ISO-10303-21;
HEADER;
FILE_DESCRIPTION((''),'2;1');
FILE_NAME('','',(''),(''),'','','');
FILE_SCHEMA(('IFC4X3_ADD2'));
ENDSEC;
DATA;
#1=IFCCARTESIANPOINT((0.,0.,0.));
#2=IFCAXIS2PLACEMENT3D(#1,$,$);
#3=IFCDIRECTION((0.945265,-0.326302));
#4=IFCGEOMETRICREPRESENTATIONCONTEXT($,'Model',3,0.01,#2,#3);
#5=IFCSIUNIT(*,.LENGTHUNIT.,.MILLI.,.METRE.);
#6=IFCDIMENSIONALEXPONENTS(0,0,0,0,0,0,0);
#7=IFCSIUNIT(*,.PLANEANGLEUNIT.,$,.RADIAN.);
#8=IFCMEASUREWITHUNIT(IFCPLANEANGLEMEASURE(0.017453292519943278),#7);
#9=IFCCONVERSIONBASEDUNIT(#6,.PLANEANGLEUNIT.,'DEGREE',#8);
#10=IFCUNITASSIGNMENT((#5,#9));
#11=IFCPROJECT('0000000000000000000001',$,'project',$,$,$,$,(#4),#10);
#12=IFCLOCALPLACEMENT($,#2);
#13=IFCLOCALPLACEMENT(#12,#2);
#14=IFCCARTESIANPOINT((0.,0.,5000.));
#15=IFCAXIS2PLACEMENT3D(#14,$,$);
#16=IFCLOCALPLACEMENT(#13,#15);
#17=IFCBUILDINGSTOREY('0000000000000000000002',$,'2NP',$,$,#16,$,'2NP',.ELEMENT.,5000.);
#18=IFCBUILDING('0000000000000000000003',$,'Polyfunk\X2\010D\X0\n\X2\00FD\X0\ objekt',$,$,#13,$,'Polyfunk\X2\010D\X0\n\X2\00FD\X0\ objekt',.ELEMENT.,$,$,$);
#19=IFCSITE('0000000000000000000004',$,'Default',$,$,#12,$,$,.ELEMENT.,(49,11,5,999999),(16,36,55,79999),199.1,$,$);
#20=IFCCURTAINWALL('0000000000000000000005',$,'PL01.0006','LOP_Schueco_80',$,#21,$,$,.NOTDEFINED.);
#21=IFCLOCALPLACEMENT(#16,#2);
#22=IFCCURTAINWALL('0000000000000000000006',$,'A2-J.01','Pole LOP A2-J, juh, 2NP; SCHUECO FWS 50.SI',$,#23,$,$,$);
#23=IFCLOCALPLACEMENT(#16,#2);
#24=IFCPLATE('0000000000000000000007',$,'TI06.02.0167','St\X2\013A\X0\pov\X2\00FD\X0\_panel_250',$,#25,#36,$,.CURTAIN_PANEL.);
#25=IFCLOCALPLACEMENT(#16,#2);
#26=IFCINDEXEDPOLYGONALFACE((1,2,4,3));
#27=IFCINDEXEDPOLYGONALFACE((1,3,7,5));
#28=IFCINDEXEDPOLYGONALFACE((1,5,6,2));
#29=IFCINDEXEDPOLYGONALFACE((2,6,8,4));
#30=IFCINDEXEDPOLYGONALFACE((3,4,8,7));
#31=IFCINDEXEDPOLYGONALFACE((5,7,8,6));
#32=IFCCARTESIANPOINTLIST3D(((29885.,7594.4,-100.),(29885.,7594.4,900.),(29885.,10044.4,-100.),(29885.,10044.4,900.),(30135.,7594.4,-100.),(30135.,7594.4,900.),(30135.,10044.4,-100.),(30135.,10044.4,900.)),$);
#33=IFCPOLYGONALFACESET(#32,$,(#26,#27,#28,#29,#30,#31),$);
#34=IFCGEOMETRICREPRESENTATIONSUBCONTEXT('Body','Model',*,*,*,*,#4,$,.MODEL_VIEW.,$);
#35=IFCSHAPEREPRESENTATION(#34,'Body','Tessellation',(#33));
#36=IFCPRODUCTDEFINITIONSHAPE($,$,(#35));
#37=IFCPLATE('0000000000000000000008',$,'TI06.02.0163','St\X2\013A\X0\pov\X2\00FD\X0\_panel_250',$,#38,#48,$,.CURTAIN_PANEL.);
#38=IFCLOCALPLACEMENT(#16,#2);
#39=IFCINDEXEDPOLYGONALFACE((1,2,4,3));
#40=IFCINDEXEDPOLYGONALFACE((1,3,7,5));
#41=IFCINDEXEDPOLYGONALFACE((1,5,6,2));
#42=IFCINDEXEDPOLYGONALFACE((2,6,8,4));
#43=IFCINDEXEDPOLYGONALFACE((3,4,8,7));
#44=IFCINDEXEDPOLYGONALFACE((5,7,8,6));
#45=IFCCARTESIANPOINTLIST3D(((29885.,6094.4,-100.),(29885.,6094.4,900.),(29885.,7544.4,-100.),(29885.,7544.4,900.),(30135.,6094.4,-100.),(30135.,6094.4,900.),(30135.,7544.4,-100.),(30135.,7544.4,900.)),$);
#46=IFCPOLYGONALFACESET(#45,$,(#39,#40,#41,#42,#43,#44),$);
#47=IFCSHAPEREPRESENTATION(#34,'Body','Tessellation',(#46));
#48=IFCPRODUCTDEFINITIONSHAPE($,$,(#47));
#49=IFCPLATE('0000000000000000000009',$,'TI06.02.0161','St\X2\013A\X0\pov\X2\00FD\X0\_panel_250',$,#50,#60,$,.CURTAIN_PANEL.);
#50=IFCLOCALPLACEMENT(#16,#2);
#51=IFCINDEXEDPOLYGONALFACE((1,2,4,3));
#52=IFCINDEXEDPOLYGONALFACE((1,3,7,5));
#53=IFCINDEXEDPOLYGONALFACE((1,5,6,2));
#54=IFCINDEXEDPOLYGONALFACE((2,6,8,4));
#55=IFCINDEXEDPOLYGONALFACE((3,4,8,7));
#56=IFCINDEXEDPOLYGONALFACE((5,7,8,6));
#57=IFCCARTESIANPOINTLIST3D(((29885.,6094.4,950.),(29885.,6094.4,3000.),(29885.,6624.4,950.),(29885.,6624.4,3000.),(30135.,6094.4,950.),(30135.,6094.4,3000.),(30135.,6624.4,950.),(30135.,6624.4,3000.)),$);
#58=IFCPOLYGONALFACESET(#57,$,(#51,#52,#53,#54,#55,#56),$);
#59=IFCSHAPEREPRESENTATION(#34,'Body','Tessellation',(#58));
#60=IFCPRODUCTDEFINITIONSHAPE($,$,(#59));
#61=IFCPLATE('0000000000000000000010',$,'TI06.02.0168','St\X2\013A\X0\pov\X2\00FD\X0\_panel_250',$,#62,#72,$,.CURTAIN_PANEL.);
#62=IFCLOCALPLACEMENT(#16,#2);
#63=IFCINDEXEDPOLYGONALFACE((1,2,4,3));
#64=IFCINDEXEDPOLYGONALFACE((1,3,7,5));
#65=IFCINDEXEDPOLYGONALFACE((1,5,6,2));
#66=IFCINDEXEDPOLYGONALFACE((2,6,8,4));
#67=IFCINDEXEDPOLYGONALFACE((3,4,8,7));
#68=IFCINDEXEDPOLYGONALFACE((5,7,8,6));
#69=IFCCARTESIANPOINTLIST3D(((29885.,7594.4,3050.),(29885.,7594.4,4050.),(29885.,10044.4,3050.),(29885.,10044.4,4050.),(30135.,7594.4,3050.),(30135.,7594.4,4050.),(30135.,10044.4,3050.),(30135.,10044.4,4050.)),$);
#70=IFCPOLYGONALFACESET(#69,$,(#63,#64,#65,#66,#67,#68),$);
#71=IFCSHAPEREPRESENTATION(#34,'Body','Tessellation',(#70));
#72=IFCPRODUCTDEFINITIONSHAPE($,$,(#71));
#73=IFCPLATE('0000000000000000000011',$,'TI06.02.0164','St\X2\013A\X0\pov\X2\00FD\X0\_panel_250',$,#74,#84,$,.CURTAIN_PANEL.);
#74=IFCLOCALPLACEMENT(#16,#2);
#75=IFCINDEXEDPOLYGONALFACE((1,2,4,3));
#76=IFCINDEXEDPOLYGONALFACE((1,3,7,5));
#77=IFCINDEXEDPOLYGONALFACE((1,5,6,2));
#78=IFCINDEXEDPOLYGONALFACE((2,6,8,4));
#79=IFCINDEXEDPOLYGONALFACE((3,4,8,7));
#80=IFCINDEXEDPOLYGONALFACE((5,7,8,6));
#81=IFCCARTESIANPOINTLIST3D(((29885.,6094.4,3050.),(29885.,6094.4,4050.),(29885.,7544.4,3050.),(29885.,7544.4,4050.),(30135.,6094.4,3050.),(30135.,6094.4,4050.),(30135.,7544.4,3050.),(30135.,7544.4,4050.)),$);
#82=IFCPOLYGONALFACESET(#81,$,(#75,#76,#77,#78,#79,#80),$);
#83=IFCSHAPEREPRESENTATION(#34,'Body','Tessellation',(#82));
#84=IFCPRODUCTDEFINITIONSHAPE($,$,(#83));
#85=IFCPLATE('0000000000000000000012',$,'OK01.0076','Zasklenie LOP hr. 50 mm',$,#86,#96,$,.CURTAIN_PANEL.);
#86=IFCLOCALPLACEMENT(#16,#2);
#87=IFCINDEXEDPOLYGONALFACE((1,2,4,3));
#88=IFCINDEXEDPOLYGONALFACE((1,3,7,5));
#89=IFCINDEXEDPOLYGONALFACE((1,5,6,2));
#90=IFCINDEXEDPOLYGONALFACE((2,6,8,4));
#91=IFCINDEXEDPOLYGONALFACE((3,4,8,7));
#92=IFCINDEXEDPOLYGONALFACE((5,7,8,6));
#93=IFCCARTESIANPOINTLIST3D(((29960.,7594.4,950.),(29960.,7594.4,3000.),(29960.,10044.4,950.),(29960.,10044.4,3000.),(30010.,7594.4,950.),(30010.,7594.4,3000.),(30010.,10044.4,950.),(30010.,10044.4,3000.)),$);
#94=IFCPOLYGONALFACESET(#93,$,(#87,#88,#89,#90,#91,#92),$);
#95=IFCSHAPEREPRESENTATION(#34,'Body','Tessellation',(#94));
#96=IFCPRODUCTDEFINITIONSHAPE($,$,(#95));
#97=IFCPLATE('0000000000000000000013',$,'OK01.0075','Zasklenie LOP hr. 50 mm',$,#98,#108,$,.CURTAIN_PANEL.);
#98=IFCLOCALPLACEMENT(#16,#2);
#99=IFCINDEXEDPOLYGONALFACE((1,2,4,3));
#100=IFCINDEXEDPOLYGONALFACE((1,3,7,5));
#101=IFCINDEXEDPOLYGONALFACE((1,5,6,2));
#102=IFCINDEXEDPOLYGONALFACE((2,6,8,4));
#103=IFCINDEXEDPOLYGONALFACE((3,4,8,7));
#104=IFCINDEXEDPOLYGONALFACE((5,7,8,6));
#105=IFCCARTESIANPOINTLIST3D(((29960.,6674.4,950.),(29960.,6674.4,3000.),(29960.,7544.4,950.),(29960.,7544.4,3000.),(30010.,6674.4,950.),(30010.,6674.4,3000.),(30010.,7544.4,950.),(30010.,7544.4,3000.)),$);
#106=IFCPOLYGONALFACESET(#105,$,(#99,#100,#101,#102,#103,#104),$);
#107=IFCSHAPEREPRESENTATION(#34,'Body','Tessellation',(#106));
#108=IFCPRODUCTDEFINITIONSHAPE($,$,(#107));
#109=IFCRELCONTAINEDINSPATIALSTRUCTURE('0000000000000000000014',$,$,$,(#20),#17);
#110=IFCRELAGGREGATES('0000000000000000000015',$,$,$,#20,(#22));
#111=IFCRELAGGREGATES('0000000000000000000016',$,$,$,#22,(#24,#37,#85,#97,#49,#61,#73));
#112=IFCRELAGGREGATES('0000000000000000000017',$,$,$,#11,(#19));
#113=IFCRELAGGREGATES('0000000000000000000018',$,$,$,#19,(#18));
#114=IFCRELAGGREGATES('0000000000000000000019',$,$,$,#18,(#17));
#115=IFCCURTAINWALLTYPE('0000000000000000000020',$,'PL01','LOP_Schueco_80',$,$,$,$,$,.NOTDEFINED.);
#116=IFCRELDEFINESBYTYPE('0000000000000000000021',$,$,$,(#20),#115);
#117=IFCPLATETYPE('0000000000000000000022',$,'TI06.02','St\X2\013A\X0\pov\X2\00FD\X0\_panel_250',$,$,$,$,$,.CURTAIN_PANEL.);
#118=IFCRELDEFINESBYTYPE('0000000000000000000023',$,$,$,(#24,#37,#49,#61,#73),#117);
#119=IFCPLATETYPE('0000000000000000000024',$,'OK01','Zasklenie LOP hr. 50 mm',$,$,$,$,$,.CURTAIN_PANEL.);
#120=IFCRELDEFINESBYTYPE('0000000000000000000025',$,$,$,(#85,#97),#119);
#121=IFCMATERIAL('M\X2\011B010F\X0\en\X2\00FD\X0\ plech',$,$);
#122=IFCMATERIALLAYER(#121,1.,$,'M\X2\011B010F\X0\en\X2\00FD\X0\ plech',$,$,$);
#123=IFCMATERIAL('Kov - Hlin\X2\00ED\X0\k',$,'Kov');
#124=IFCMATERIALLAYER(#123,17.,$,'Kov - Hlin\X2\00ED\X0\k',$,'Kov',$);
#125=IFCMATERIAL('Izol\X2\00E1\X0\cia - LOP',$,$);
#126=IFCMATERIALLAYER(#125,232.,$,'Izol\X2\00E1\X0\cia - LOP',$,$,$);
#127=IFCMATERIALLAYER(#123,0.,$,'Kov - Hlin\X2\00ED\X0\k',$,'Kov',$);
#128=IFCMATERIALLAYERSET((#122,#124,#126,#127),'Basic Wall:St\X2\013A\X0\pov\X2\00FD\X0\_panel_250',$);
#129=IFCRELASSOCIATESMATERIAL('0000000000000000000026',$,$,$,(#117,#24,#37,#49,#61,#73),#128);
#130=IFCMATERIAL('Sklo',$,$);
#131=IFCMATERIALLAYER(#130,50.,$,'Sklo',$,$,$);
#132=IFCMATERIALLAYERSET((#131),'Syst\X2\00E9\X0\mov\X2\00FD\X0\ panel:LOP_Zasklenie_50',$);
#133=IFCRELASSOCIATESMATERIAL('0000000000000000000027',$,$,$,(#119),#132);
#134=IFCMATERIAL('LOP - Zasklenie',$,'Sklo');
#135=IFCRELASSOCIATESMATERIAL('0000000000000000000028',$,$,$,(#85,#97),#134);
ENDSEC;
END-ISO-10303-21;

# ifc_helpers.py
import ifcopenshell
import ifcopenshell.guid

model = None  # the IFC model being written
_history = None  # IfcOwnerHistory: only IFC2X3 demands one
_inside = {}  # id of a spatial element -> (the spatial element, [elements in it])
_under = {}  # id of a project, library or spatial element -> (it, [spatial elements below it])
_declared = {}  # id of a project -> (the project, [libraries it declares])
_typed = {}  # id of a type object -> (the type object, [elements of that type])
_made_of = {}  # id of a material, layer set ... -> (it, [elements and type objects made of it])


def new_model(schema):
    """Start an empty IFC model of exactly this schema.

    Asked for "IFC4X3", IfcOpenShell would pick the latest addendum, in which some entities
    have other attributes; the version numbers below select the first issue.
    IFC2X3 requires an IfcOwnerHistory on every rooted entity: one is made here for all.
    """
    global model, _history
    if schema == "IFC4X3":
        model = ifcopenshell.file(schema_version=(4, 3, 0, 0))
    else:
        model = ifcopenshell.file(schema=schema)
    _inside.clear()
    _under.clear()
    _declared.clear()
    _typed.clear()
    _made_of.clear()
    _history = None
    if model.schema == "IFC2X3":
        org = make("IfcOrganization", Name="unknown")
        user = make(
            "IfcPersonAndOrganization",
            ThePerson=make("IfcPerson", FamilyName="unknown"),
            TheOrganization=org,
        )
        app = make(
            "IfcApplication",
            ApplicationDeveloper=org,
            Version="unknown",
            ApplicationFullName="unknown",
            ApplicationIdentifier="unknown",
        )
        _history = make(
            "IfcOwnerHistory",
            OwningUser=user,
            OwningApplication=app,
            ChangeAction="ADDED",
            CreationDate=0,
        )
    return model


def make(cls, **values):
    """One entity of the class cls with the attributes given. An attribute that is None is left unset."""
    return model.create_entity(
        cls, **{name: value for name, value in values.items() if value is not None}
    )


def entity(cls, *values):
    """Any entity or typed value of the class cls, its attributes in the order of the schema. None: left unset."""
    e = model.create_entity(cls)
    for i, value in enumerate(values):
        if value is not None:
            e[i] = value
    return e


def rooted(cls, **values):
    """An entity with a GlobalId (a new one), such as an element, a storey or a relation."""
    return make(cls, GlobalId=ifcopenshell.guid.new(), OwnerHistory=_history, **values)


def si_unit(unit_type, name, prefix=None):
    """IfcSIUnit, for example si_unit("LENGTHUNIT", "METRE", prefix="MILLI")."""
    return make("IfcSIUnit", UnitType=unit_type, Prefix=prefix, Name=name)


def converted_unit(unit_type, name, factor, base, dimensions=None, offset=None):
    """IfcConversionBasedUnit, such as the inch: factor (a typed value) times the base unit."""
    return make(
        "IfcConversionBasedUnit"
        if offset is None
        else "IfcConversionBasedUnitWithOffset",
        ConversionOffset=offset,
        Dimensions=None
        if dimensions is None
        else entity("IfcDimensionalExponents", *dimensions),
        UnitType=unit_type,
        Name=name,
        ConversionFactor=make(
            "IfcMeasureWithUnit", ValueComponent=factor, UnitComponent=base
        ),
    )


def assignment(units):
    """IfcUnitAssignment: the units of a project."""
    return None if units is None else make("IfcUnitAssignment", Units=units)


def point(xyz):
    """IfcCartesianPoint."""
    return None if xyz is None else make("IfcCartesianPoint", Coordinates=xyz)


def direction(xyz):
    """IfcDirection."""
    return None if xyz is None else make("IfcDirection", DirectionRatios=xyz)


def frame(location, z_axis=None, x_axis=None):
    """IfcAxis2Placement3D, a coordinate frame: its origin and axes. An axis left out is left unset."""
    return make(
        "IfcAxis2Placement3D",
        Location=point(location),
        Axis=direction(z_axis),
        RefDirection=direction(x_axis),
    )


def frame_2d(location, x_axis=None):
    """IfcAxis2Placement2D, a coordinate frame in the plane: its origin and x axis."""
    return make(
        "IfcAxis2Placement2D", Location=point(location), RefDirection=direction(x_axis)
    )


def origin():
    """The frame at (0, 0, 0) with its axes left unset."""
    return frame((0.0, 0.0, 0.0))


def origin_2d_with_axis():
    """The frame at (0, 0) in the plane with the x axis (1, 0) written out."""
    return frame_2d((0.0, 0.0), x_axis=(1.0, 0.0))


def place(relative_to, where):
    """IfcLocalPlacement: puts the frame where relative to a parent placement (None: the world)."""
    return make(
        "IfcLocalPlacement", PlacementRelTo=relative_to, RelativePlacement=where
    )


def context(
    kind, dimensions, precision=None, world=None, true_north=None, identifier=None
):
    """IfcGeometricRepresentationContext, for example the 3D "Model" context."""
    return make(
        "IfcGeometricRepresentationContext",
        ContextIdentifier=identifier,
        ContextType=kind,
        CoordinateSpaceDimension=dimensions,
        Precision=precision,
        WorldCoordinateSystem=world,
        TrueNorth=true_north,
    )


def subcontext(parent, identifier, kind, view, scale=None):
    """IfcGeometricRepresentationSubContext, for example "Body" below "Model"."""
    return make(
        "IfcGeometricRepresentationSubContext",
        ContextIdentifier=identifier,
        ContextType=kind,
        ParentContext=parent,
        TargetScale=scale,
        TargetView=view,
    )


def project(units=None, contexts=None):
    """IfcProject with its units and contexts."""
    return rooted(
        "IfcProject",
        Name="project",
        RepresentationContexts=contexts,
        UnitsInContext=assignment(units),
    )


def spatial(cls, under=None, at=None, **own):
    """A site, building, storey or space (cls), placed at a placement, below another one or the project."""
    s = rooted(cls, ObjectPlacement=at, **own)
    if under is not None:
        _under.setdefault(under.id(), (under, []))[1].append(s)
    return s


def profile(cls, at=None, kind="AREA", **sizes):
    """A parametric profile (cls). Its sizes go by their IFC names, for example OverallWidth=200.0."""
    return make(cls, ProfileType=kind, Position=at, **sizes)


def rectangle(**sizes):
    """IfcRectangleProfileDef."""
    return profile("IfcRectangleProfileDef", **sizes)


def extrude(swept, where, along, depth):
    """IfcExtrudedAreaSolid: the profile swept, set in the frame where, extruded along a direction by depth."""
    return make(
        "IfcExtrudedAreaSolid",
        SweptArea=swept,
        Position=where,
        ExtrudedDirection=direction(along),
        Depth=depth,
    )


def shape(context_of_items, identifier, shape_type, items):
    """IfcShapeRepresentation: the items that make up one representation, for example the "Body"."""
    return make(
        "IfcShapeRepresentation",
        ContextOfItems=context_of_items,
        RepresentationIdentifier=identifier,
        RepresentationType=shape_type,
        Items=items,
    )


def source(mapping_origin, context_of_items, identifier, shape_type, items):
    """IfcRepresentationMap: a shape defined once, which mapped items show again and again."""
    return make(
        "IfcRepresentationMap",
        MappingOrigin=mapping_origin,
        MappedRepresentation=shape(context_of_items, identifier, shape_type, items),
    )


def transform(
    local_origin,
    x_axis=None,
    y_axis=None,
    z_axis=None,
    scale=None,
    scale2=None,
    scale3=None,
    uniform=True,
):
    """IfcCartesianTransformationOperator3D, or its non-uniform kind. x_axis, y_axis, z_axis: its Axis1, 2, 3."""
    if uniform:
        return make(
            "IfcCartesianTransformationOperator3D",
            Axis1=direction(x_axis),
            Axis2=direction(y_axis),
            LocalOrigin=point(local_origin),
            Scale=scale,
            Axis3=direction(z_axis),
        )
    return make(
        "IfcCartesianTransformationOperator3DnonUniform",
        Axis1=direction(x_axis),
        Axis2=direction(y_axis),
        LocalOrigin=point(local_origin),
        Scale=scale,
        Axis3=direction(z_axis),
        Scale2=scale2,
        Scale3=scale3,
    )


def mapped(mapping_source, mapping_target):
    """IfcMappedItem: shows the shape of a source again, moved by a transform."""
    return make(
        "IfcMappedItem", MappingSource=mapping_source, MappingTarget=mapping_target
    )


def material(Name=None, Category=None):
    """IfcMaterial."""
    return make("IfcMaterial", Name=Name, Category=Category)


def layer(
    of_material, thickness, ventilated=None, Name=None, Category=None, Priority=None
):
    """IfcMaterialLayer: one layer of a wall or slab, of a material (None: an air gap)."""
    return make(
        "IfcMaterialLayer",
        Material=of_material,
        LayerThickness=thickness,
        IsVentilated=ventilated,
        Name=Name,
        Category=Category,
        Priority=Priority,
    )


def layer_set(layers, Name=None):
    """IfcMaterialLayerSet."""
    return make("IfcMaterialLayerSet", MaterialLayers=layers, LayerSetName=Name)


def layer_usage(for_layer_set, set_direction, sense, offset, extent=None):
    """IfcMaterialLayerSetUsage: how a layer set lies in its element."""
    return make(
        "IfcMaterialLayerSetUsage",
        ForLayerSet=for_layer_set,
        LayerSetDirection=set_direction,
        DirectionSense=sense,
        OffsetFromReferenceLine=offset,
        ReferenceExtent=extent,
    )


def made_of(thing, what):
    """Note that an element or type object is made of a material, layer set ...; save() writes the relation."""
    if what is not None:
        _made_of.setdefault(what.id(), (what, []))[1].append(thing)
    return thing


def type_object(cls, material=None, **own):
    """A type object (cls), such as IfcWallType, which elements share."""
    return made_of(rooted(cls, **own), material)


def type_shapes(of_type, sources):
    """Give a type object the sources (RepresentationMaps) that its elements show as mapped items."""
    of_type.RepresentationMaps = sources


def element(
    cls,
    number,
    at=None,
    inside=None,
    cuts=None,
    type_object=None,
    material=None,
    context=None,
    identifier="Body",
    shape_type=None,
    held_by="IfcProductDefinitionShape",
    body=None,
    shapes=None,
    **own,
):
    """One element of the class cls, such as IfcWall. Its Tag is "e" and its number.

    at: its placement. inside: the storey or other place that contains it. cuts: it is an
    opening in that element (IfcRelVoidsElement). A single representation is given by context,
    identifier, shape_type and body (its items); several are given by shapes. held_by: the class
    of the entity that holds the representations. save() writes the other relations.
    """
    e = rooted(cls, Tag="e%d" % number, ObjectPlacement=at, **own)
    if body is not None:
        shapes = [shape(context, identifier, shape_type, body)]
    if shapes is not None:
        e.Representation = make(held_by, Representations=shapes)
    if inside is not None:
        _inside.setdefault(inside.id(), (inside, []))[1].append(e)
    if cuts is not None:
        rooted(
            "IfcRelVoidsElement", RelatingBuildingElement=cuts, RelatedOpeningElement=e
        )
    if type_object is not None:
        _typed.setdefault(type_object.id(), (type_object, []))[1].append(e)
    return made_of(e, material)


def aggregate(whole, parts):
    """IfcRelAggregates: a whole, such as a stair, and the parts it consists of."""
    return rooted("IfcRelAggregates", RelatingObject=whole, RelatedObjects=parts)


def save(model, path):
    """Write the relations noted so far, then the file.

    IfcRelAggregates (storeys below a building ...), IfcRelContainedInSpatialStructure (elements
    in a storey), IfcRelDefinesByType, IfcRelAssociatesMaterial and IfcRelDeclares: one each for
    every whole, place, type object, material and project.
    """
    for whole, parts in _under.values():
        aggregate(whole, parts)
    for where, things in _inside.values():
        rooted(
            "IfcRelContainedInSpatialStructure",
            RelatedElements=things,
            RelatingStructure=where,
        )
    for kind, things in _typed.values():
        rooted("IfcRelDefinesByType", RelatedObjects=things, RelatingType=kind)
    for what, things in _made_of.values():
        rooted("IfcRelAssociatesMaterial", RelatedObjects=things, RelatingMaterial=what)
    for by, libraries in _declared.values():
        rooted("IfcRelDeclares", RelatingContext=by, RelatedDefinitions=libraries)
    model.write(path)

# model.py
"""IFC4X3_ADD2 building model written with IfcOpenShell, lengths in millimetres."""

from ifc_helpers import new_model, entity, si_unit, converted_unit, direction, frame, frame_2d, origin, origin_2d_with_axis, place, context, subcontext, project, spatial, rectangle, extrude, source, transform, mapped, material, layer, layer_set, layer_usage, type_object, type_shapes, element, aggregate, save


model = new_model("IFC4X3_ADD2")

# Units and contexts
model_context = context("Model", 3, precision=0.01, world=origin(), true_north=direction((0.945265, -0.326302)))
body_context = subcontext(model_context, "Body", "Model", "MODEL_VIEW")
ifc_project = project(units=[si_unit("LENGTHUNIT", "METRE", prefix="MILLI"), converted_unit("PLANEANGLEUNIT", "DEGREE", entity("IfcPlaneAngleMeasure", 0.017453292519943278), si_unit("PLANEANGLEUNIT", "RADIAN"), dimensions=[0, 0, 0, 0, 0, 0, 0])], contexts=[model_context])

# Site, building, storey
site_placement = place(None, origin())
site = spatial("IfcSite", under=ifc_project, at=site_placement, Name="Default", CompositionType="ELEMENT", RefLatitude=(49, 11, 5, 999999), RefLongitude=(16, 36, 55, 79999), RefElevation=199.1)
building_placement = place(site_placement, origin())
building = spatial("IfcBuilding", under=site, at=building_placement, Name="Polyfunkčný objekt", LongName="Polyfunkčný objekt", CompositionType="ELEMENT")
storey_placement = place(building_placement, frame((0.0, 0.0, 5000.0)))
storey = spatial("IfcBuildingStorey", under=building, at=storey_placement, Name="2NP", LongName="2NP", CompositionType="ELEMENT", Elevation=5000.0)

# Curtain walls, plates
curtain_wall_type = type_object("IfcCurtainWallType", Name="PL01", Description="LOP_Schueco_80", PredefinedType="NOTDEFINED")
curtain_wall_1_placement = place(storey_placement, frame((0.0, 0.0, -5000.0)))
curtain_wall_1 = element("IfcCurtainWall", 1, at=curtain_wall_1_placement, inside=storey, type_object=curtain_wall_type, Name="PL01.0006", Description="LOP_Schueco_80", PredefinedType="NOTDEFINED")
curtain_wall_2 = element("IfcCurtainWall", 2, Name="A2-J.01", Description="Pole LOP A2-J, juh, 2NP; SCHUECO FWS 50.SI")
aggregate(curtain_wall_1, [curtain_wall_2])
ifc_material_1 = material(Name="Měďený plech")
ifc_layer_1 = layer(ifc_material_1, 1.0, Name="Měďený plech")
ifc_material_2 = material(Name="Kov - Hliník", Category="Kov")
ifc_layer_2 = layer(ifc_material_2, 17.0, Name="Kov - Hliník", Category="Kov")
ifc_material_3 = material(Name="Izolácia - LOP")
ifc_layer_3 = layer(ifc_material_3, 232.0, Name="Izolácia - LOP")
ifc_layer_4 = layer(ifc_material_2, 0.0, Name="Kov - Hliník", Category="Kov")
ifc_layer_set_1 = layer_set([ifc_layer_1, ifc_layer_2, ifc_layer_3, ifc_layer_4], Name="Basic Wall:Stĺpový_panel_250")
ifc_layer_usage_1 = layer_usage(ifc_layer_set_1, "AXIS2", "POSITIVE", -125.0)
plate_type_1 = type_object("IfcPlateType", Name="TI06.02", Description="Stĺpový_panel_250", PredefinedType="CURTAIN_PANEL", material=ifc_layer_set_1)
plate_1_placement = place(storey_placement, frame((30010.0, 10044.4, -100.0), z_axis=(0.0, 0.0, 1.0), x_axis=(0.0, -1.0, 0.0)))
plate_1 = element("IfcPlate", 3, at=plate_1_placement, type_object=plate_type_1, material=ifc_layer_usage_1, Name="TI06.02.0167", Description="Stĺpový_panel_250", PredefinedType="CURTAIN_PANEL", context=body_context, shape_type="SweptSolid", body=[
    extrude(rectangle(XDim=250.0, YDim=2450.0, at=origin_2d_with_axis()), frame((1225.0, 0.0, 0.0), z_axis=(0.0, 0.0, 1.0), x_axis=(0.0, 1.0, 0.0)), (0.0, 0.0, 1.0), 1000.0),
])
ifc_layer_usage_2 = layer_usage(ifc_layer_set_1, "AXIS2", "POSITIVE", -125.0)
plate_2_placement = place(storey_placement, frame((30010.0, 7544.4, -100.0), z_axis=(0.0, 0.0, 1.0), x_axis=(0.0, -1.0, 0.0)))
plate_2 = element("IfcPlate", 4, at=plate_2_placement, type_object=plate_type_1, material=ifc_layer_usage_2, Name="TI06.02.0163", Description="Stĺpový_panel_250", PredefinedType="CURTAIN_PANEL", context=body_context, shape_type="SweptSolid", body=[
    extrude(rectangle(XDim=250.0, YDim=1450.0, at=frame_2d((0.0, 0.0), x_axis=(1.0, 0.0))), frame((725.0, 0.0, 0.0), z_axis=(0.0, 0.0, 1.0), x_axis=(0.0, 1.0, 0.0)), (0.0, 0.0, 1.0), 1000.0),
])
ifc_layer_usage_3 = layer_usage(ifc_layer_set_1, "AXIS2", "POSITIVE", -125.0)
plate_3_placement = place(storey_placement, frame((30010.0, 6624.4, 950.0), z_axis=(0.0, 0.0, 1.0), x_axis=(0.0, -1.0, 0.0)))
plate_3 = element("IfcPlate", 5, at=plate_3_placement, type_object=plate_type_1, material=ifc_layer_usage_3, Name="TI06.02.0161", Description="Stĺpový_panel_250", PredefinedType="CURTAIN_PANEL", context=body_context, shape_type="SweptSolid", body=[
    extrude(rectangle(XDim=250.0, YDim=530.0, at=frame_2d((0.0, 0.0), x_axis=(1.0, 0.0))), frame((265.0, 0.0, 0.0), z_axis=(0.0, 0.0, 1.0), x_axis=(0.0, 1.0, 0.0)), (0.0, 0.0, 1.0), 2050.0),
])
ifc_layer_usage_4 = layer_usage(ifc_layer_set_1, "AXIS2", "POSITIVE", -125.0)
plate_4_placement = place(storey_placement, frame((30010.0, 10044.4, 3050.0), z_axis=(0.0, 0.0, 1.0), x_axis=(0.0, -1.0, 0.0)))
plate_4 = element("IfcPlate", 6, at=plate_4_placement, type_object=plate_type_1, material=ifc_layer_usage_4, Name="TI06.02.0168", Description="Stĺpový_panel_250", PredefinedType="CURTAIN_PANEL", context=body_context, shape_type="SweptSolid", body=[
    extrude(rectangle(XDim=250.0, YDim=2450.0, at=origin_2d_with_axis()), frame((1225.0, 0.0, 0.0), z_axis=(0.0, 0.0, 1.0), x_axis=(0.0, 1.0, 0.0)), (0.0, 0.0, 1.0), 1000.0),
])
ifc_layer_usage_5 = layer_usage(ifc_layer_set_1, "AXIS2", "POSITIVE", -125.0)
plate_5_placement = place(storey_placement, frame((30010.0, 7544.4, 3050.0), z_axis=(0.0, 0.0, 1.0), x_axis=(0.0, -1.0, 0.0)))
plate_5 = element("IfcPlate", 7, at=plate_5_placement, type_object=plate_type_1, material=ifc_layer_usage_5, Name="TI06.02.0164", Description="Stĺpový_panel_250", PredefinedType="CURTAIN_PANEL", context=body_context, shape_type="SweptSolid", body=[
    extrude(rectangle(XDim=250.0, YDim=1450.0, at=frame_2d((0.0, 0.0), x_axis=(1.0, 0.0))), frame((725.0, 0.0, 0.0), z_axis=(0.0, 0.0, 1.0), x_axis=(0.0, 1.0, 0.0)), (0.0, 0.0, 1.0), 1000.0),
])
ifc_material_4 = material(Name="LOP - Zasklenie", Category="Sklo")
ifc_material_5 = material(Name="Sklo")
ifc_layer_5 = layer(ifc_material_5, 50.0, Name="Sklo")
ifc_layer_set_2 = layer_set([ifc_layer_5], Name="Systémový panel:LOP_Zasklenie_50")
plate_type_2 = type_object("IfcPlateType", Name="OK01", Description="Zasklenie LOP hr. 50 mm", PredefinedType="CURTAIN_PANEL", material=ifc_layer_set_2)
shared_shape_1 = source(origin(), body_context, "Body", "SweptSolid", [
    extrude(rectangle(XDim=50.0, YDim=2450.0, at=origin_2d_with_axis()), frame((0.0, -25.0, 0.0), z_axis=(0.0, 0.0, 1.0), x_axis=(0.0, 1.0, 0.0)), (0.0, 0.0, 1.0), 2050.0),
])
plate_6_placement = place(curtain_wall_1_placement, frame((30010.0, 8819.4, 5950.0), z_axis=(0.0, 0.0, 1.0), x_axis=(0.0, -1.0, 0.0)))
plate_6 = element("IfcPlate", 8, at=plate_6_placement, type_object=plate_type_2, material=ifc_material_4, Name="OK01.0076", Description="Zasklenie LOP hr. 50 mm", PredefinedType="CURTAIN_PANEL", context=body_context, shape_type="MappedRepresentation", body=[
    mapped(shared_shape_1, transform((0.0, 0.0, 0.0), scale=1.0)),
])
shared_shape_2 = source(origin(), body_context, "Body", "SweptSolid", [
    extrude(rectangle(XDim=50.0, YDim=870.0, at=origin_2d_with_axis()), frame((0.0, -25.0, 0.0), z_axis=(0.0, 0.0, 1.0), x_axis=(0.0, 1.0, 0.0)), (0.0, 0.0, 1.0), 2050.0),
])
type_shapes(plate_type_2, [shared_shape_1, shared_shape_2])
plate_7_placement = place(curtain_wall_1_placement, frame((30010.0, 7109.4, 5950.0), z_axis=(0.0, 0.0, 1.0), x_axis=(0.0, -1.0, 0.0)))
plate_7 = element("IfcPlate", 9, at=plate_7_placement, type_object=plate_type_2, material=ifc_material_4, Name="OK01.0075", Description="Zasklenie LOP hr. 50 mm", PredefinedType="CURTAIN_PANEL", context=body_context, shape_type="MappedRepresentation", body=[
    mapped(shared_shape_2, transform((0.0, 0.0, 0.0), scale=1.0)),
])
aggregate(curtain_wall_2, [plate_1, plate_2, plate_6, plate_7, plate_3, plate_4, plate_5])

save(model, "model.ifc")
